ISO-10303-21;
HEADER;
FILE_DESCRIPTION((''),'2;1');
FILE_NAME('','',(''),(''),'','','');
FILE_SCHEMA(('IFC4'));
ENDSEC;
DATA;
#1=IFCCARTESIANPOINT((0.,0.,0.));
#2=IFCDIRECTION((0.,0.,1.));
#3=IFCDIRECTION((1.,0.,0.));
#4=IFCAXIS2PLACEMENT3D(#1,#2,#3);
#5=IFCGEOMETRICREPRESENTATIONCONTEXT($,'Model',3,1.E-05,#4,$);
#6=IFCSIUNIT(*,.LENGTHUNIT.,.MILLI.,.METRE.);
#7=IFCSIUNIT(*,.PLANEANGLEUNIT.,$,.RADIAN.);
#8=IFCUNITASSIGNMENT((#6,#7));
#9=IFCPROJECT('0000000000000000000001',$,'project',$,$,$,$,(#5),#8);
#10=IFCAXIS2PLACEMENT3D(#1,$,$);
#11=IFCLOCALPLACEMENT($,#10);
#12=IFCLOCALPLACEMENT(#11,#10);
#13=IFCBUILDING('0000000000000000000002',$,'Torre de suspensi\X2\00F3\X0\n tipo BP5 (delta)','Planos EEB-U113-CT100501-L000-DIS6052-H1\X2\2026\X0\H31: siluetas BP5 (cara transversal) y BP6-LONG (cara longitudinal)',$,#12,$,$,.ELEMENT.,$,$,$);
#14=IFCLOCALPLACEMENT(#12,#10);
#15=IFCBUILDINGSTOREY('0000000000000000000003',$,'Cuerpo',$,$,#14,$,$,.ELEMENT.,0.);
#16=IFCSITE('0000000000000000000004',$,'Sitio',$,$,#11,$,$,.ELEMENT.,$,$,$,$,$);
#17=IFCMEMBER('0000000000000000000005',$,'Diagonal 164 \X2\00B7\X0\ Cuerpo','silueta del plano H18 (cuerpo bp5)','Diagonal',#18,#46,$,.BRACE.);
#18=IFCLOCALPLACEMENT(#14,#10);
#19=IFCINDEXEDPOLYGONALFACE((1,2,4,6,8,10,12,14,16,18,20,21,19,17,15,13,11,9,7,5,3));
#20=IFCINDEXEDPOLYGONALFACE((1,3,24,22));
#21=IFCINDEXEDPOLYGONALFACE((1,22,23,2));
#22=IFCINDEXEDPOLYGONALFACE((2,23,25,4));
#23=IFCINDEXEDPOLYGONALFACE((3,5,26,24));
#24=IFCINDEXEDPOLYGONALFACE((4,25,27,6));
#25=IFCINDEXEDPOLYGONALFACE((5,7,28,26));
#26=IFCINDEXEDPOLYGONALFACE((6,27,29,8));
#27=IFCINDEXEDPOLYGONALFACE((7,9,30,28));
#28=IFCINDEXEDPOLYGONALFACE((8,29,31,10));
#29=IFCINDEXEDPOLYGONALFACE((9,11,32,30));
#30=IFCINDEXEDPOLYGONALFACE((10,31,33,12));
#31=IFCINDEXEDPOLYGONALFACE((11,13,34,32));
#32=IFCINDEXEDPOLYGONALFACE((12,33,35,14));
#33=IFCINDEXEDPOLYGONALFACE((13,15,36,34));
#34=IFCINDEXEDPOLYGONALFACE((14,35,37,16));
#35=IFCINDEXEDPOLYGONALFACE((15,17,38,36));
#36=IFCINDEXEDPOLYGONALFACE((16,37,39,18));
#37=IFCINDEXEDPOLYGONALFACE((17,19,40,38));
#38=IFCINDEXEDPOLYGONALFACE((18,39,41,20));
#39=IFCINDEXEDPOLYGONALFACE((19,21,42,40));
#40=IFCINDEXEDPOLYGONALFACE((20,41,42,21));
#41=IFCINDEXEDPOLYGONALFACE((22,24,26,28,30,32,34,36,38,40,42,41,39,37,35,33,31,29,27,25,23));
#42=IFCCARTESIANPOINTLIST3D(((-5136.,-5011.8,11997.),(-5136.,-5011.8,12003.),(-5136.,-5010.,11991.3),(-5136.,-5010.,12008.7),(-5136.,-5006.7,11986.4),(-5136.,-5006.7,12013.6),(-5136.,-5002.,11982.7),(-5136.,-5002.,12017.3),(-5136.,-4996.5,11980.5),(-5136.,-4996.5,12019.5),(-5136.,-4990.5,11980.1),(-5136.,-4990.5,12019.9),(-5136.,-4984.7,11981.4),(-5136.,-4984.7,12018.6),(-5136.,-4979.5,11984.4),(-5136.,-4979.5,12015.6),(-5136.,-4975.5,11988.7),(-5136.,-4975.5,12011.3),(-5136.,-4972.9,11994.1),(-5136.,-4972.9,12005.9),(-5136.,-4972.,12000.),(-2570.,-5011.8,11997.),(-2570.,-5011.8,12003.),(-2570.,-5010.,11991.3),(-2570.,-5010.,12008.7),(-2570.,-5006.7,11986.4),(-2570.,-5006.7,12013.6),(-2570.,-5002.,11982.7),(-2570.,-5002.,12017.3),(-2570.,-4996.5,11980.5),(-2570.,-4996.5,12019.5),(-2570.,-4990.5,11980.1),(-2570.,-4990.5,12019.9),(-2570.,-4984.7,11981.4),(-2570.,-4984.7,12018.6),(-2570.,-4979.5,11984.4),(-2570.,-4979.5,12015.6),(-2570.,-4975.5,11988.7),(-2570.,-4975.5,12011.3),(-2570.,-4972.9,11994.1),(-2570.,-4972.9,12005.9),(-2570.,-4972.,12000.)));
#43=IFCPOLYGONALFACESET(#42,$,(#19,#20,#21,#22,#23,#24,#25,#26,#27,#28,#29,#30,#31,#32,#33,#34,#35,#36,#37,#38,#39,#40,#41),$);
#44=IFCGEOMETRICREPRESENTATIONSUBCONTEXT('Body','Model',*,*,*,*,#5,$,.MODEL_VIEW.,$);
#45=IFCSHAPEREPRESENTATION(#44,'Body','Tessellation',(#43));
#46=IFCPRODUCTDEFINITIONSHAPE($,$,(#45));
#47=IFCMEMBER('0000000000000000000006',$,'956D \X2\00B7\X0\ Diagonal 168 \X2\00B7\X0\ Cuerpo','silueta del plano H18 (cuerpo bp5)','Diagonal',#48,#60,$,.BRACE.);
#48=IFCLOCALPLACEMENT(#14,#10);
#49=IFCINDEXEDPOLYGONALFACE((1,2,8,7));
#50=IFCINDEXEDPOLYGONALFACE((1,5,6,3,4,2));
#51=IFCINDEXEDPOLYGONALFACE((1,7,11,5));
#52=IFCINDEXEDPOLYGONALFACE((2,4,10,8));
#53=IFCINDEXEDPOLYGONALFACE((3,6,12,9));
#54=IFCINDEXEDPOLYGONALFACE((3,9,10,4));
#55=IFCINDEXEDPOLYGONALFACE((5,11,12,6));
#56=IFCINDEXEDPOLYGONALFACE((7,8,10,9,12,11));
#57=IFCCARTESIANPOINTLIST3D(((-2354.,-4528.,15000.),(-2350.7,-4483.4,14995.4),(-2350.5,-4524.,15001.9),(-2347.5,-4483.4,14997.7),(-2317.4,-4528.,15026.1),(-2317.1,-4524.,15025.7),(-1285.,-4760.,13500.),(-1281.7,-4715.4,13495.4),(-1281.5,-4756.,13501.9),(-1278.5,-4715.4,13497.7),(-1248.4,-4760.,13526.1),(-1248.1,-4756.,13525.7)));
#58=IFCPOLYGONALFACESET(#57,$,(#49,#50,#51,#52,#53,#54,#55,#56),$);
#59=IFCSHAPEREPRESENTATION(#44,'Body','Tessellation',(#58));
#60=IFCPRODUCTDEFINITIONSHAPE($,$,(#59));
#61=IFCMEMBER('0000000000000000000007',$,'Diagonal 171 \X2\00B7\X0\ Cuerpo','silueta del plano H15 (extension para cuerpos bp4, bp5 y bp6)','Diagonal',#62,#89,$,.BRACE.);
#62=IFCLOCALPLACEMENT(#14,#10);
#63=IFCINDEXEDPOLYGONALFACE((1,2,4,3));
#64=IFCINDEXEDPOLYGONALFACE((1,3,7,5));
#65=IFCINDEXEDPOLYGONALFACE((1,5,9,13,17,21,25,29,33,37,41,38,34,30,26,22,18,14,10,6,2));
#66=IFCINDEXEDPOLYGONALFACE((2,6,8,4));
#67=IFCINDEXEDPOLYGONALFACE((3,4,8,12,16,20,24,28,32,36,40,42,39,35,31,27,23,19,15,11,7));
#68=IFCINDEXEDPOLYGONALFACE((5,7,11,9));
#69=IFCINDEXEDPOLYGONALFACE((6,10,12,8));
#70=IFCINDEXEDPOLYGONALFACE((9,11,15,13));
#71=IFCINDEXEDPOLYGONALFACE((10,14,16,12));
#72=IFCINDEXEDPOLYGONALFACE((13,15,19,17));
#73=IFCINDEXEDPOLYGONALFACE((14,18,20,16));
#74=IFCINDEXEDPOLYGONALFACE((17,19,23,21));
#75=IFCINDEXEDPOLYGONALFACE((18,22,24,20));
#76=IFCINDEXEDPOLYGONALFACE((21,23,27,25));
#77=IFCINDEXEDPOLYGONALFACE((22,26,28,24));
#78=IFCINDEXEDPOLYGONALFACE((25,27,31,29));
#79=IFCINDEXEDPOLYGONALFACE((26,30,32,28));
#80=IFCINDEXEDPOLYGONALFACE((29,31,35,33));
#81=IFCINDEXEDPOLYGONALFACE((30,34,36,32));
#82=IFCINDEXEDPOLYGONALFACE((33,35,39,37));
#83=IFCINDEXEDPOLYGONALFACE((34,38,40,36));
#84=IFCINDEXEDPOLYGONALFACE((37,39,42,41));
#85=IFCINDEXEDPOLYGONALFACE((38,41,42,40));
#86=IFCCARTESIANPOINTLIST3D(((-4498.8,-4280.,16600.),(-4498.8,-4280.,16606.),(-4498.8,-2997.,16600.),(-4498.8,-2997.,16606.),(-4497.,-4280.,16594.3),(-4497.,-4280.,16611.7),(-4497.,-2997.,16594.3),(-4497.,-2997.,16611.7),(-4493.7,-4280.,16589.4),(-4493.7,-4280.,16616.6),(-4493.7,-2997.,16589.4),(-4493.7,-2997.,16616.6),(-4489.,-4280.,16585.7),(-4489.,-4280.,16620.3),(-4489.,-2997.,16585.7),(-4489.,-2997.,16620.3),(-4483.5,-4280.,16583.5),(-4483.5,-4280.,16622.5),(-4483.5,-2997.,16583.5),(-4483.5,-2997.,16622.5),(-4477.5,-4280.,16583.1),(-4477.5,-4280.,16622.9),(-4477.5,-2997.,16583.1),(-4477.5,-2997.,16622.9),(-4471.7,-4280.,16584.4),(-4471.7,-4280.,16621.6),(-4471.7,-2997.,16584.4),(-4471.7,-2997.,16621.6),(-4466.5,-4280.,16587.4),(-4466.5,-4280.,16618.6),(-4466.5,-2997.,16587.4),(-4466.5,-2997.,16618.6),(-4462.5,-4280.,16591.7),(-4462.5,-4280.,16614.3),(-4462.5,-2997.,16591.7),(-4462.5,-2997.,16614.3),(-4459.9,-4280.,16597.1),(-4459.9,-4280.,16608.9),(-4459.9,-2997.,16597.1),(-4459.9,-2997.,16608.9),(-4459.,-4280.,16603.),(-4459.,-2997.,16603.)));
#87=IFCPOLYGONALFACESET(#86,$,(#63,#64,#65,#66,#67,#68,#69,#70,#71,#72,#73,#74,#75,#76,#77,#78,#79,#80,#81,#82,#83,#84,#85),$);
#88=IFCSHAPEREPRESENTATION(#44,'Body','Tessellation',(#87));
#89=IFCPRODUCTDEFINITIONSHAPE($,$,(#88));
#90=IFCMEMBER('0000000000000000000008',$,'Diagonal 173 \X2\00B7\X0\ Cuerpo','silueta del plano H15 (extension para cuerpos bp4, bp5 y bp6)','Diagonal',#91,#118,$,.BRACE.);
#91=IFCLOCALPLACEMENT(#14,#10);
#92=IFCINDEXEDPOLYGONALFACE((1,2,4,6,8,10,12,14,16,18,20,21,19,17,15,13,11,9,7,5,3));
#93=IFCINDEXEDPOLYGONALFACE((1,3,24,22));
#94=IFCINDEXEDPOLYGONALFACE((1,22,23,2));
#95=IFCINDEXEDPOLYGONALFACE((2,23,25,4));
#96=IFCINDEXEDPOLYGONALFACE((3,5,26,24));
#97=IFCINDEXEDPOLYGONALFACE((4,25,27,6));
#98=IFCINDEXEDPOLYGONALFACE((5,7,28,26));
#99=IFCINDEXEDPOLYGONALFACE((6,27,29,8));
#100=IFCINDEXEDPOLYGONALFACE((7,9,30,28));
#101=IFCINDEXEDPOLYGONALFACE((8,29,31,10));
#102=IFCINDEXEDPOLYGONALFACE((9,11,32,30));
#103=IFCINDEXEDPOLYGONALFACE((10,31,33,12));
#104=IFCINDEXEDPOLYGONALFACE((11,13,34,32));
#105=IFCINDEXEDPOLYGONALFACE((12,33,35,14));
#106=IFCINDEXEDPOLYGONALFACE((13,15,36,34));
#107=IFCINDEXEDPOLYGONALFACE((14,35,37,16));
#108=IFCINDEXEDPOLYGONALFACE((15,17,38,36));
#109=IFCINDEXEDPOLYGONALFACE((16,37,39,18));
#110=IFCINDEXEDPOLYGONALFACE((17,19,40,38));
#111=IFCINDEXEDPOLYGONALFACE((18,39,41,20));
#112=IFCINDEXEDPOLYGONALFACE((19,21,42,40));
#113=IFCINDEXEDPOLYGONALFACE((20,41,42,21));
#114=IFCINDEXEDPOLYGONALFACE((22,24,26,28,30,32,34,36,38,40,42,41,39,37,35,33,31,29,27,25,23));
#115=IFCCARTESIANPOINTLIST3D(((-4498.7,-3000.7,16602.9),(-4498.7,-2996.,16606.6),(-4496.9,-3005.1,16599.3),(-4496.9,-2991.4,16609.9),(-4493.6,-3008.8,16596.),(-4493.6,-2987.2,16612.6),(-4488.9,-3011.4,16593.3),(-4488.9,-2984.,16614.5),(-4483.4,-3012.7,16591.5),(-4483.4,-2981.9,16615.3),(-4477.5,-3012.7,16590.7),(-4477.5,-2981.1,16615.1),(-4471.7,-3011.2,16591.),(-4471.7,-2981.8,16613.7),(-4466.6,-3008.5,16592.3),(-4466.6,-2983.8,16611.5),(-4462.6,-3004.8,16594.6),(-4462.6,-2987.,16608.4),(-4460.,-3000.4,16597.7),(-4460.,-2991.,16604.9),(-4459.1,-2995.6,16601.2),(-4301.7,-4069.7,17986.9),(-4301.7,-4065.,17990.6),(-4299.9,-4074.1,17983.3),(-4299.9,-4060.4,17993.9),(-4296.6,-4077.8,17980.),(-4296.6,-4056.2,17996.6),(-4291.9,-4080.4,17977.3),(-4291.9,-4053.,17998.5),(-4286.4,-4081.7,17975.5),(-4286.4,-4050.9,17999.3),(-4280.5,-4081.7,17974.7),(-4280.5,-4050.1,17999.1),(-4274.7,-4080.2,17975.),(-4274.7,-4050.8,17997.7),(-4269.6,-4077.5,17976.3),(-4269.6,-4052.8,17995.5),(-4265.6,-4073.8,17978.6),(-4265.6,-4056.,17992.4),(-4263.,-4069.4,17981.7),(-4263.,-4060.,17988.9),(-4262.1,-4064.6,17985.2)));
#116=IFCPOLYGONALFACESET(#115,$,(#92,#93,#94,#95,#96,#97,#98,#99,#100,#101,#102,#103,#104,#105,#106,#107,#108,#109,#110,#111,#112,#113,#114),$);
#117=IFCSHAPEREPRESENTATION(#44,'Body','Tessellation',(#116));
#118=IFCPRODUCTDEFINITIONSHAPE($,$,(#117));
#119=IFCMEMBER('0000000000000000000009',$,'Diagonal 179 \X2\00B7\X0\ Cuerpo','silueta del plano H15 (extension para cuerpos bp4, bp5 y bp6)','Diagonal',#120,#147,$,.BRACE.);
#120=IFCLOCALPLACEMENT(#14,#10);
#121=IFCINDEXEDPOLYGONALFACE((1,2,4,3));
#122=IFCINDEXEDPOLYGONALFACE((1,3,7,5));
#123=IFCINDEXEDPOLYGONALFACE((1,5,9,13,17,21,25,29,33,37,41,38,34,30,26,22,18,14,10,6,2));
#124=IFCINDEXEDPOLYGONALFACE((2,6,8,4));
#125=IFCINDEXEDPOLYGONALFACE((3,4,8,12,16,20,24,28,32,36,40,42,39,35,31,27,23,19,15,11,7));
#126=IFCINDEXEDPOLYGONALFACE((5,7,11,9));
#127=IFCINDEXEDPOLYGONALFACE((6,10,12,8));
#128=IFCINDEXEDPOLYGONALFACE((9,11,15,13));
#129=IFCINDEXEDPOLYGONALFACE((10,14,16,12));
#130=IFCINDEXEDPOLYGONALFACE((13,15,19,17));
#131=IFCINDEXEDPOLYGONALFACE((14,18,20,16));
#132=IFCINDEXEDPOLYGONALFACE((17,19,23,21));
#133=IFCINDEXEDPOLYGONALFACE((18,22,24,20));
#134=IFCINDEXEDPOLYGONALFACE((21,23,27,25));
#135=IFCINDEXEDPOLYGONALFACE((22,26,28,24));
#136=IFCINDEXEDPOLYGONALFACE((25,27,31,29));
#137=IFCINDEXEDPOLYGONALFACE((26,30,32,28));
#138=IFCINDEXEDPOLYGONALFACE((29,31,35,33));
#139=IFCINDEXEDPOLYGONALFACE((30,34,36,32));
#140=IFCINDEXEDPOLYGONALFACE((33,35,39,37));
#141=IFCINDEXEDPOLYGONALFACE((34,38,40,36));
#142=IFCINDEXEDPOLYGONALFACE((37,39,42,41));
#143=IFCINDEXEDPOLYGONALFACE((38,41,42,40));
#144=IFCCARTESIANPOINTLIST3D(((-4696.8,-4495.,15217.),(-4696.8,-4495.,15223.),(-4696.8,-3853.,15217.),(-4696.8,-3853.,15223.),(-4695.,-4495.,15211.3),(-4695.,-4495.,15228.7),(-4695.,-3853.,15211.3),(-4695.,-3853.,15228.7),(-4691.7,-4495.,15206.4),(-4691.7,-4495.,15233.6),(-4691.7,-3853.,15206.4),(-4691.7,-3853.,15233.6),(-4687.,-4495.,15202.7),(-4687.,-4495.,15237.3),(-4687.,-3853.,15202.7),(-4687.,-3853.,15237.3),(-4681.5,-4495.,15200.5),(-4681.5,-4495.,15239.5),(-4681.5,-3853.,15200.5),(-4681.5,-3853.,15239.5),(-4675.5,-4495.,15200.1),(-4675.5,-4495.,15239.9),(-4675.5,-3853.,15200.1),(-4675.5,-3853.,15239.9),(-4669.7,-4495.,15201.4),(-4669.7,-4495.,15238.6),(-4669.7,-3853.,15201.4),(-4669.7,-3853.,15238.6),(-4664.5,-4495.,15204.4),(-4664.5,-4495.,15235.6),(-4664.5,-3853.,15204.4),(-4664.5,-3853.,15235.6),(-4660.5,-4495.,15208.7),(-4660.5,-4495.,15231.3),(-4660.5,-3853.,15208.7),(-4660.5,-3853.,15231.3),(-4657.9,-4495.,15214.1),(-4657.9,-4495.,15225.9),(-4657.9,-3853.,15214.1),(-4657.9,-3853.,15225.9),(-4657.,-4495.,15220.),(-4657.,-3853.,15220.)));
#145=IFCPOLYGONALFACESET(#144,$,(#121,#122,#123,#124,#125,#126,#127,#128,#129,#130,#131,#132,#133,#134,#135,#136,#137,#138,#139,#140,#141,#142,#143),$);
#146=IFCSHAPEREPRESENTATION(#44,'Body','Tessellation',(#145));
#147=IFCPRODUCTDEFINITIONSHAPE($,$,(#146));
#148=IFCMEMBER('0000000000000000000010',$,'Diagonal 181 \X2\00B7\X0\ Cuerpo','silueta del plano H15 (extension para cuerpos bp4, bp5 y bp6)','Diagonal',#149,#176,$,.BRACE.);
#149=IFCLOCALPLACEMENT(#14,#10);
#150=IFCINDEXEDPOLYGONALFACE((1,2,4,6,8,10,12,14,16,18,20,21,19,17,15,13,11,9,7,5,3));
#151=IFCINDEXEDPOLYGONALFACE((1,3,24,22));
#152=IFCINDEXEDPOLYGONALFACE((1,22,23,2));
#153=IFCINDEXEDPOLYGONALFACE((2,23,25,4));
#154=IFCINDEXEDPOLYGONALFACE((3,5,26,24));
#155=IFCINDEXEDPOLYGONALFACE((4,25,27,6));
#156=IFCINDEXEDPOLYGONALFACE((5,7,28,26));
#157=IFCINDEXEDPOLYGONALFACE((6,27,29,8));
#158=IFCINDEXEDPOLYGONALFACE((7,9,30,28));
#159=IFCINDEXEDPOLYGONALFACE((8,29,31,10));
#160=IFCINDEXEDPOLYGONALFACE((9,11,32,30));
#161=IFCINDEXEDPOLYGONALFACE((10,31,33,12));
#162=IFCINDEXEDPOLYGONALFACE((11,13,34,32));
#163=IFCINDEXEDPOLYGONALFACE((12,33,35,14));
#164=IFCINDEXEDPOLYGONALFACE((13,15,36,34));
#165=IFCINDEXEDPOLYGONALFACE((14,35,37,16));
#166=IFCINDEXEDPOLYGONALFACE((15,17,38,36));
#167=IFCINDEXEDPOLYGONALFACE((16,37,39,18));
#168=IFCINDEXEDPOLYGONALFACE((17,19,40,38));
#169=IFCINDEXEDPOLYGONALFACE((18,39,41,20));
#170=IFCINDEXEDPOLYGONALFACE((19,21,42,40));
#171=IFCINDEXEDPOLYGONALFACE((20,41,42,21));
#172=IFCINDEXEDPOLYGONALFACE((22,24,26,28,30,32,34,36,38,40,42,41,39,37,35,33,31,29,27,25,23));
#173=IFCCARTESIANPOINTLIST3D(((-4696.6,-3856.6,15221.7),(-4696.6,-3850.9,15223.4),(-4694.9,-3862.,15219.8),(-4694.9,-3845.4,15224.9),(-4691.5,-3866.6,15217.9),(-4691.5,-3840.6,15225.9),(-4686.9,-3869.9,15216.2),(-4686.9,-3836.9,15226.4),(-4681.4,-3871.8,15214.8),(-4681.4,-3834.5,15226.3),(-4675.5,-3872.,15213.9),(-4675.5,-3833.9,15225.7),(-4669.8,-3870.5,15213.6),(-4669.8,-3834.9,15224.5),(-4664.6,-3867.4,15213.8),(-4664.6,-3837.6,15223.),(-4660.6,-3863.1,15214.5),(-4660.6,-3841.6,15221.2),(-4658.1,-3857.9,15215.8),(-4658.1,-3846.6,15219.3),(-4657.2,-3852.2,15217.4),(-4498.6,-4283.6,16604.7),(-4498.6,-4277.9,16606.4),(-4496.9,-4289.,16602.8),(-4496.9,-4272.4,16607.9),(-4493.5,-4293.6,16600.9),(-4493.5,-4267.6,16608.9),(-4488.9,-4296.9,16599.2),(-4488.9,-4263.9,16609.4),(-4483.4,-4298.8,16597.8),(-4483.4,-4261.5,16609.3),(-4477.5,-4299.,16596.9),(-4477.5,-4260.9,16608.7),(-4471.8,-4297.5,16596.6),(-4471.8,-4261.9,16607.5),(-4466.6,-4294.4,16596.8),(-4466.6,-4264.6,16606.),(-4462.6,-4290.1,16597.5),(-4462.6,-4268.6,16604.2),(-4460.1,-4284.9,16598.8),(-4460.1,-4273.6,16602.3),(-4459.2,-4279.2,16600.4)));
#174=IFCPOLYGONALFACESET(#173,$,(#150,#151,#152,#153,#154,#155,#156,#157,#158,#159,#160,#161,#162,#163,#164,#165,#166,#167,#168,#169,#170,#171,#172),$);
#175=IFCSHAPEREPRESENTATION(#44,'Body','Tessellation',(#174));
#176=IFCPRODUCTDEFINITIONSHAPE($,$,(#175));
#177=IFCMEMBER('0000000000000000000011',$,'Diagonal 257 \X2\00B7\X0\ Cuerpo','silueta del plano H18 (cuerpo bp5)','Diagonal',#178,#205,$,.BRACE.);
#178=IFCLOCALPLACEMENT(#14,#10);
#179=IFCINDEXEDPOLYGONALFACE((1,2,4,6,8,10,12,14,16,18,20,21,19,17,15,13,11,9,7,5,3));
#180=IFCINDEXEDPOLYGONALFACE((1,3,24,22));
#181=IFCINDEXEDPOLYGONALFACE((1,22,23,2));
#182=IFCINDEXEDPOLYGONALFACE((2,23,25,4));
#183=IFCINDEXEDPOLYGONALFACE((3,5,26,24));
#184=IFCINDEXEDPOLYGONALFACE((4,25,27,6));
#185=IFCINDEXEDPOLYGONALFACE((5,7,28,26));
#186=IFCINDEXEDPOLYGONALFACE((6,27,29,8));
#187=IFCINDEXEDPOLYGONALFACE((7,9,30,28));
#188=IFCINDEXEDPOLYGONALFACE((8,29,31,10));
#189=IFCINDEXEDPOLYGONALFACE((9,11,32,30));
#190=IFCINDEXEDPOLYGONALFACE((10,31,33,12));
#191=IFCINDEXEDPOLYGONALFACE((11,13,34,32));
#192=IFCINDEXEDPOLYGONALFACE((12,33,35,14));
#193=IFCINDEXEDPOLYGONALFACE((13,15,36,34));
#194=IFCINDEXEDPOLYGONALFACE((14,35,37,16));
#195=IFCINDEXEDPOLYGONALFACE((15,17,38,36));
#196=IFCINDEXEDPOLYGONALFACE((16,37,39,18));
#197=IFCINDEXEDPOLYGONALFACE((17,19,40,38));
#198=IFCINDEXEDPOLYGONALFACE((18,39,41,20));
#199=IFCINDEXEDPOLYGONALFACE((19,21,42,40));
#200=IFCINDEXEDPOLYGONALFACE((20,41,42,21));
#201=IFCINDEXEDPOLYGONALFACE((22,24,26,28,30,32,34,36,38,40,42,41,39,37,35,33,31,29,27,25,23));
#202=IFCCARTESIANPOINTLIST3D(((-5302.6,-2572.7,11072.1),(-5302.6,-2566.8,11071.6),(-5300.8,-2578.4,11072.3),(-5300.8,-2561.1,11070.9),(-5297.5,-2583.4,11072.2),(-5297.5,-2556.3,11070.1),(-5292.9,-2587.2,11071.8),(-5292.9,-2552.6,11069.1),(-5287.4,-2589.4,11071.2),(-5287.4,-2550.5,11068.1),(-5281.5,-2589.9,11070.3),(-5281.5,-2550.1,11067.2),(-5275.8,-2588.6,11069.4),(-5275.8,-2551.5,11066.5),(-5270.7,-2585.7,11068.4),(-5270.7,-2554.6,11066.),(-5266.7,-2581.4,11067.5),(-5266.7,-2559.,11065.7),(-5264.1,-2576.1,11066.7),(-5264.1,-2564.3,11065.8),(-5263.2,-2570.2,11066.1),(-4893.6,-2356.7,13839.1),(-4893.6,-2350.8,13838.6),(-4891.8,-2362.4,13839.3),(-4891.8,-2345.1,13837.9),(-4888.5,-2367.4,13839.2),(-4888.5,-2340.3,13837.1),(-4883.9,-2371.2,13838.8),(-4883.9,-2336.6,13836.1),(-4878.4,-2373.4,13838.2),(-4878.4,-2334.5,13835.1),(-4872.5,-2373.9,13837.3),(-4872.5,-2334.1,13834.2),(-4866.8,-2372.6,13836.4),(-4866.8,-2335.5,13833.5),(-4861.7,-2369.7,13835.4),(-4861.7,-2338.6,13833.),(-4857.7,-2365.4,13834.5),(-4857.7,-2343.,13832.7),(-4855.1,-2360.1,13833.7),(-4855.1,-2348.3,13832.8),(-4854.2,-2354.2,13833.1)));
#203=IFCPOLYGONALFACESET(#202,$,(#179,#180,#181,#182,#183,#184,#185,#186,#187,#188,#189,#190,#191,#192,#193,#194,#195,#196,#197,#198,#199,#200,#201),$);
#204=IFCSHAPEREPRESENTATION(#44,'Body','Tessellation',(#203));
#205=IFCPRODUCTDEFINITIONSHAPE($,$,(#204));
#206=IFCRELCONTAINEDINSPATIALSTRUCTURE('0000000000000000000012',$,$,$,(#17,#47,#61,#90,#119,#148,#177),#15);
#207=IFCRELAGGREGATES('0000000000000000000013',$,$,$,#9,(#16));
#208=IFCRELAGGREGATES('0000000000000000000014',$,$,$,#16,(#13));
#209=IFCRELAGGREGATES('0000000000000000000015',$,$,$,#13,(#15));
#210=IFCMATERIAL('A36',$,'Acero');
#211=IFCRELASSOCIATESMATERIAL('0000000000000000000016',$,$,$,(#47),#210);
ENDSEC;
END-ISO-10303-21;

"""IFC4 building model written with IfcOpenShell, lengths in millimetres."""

from ifc_helpers import new_model, si_unit, frame, frame_2d, origin, origin_with_axes, place, context, subcontext, project, spatial, circle, l_section, extrude, material, element, save


model = new_model("IFC4")

# Units and contexts
model_context = context("Model", 3, precision=1e-05, world=origin_with_axes())
body_context = subcontext(model_context, "Body", "Model", "MODEL_VIEW")
ifc_project = project(units=[si_unit("LENGTHUNIT", "METRE", prefix="MILLI"), si_unit("PLANEANGLEUNIT", "RADIAN")], contexts=[model_context])

# Site, building, storey
site_placement = place(None, origin())
site = spatial("IfcSite", under=ifc_project, at=site_placement, Name="Sitio", CompositionType="ELEMENT")
building_placement = place(site_placement, origin())
building = spatial("IfcBuilding", under=site, at=building_placement, Name="Torre de suspensión tipo BP5 (delta)", Description="Planos EEB-U113-CT100501-L000-DIS6052-H1…H31: siluetas BP5 (cara transversal) y BP6-LONG (cara longitudinal)", CompositionType="ELEMENT")
storey_placement = place(building_placement, origin())
storey = spatial("IfcBuildingStorey", under=building, at=storey_placement, Name="Cuerpo", CompositionType="ELEMENT", Elevation=0.0)

# Members
ifc_material_1 = material(Name="A36", Category="Acero")
member_1_placement = place(storey_placement, frame((-5136.0, -4992.0, 12000.0), z_axis=(1.0, 0.0, 0.0), x_axis=(0.0, 1.0, 0.0)))
element("IfcMember", 1, at=member_1_placement, inside=storey, Name="Diagonal 164 · Cuerpo", Description="silueta del plano H18 (cuerpo bp5)", ObjectType="Diagonal", PredefinedType="BRACE", context=body_context, shape_type="SweptSolid", body=[
    extrude(circle(Radius=20.0), None, (0.0, 0.0, 1.0), 2566.0),
])
member_2_placement = place(storey_placement, frame((-2354.0, -4528.0, 15000.0), z_axis=(0.575815, -0.124966, -0.807973), x_axis=(0.072526, 0.992161, -0.101767)))
element("IfcMember", 2, at=member_2_placement, inside=storey, material=ifc_material_1, Name="956D · Diagonal 168 · Cuerpo", Description="silueta del plano H18 (cuerpo bp5)", ObjectType="Diagonal", PredefinedType="BRACE", context=body_context, shape_type="SweptSolid", body=[
    extrude(l_section(Depth=45.0, Width=45.0, Thickness=4.0, at=frame_2d((22.5, 22.5))), None, (0.0, 0.0, 1.0), 1856.5),
])
member_3_placement = place(storey_placement, frame((-4479.0, -2997.0, 16603.0), z_axis=(0.0, -1.0, 0.0), x_axis=(1.0, 0.0, 0.0)))
element("IfcMember", 3, at=member_3_placement, inside=storey, Name="Diagonal 171 · Cuerpo", Description="silueta del plano H15 (extension para cuerpos bp4, bp5 y bp6)", ObjectType="Diagonal", PredefinedType="BRACE", context=body_context, shape_type="SweptSolid", body=[
    extrude(circle(Radius=20.0), None, (0.0, 0.0, 1.0), 1283.0),
])
member_4_placement = place(storey_placement, frame((-4479.0, -2997.0, 16603.0), z_axis=(0.111942, -0.607443, 0.786437), x_axis=(0.993715, 0.068429, -0.088592)))
element("IfcMember", 4, at=member_4_placement, inside=storey, Name="Diagonal 173 · Cuerpo", Description="silueta del plano H15 (extension para cuerpos bp4, bp5 y bp6)", ObjectType="Diagonal", PredefinedType="BRACE", context=body_context, shape_type="SweptSolid", body=[
    extrude(circle(Radius=20.0), None, (0.0, 0.0, 1.0), 1759.8),
])
member_5_placement = place(storey_placement, frame((-4677.0, -3853.0, 15220.0), z_axis=(0.0, -1.0, 0.0), x_axis=(1.0, 0.0, 0.0)))
element("IfcMember", 5, at=member_5_placement, inside=storey, Name="Diagonal 179 · Cuerpo", Description="silueta del plano H15 (extension para cuerpos bp4, bp5 y bp6)", ObjectType="Diagonal", PredefinedType="BRACE", context=body_context, shape_type="SweptSolid", body=[
    extrude(circle(Radius=20.0), None, (0.0, 0.0, 1.0), 642.0),
])
member_6_placement = place(storey_placement, frame((-4677.0, -3853.0, 15220.0), z_axis=(0.135533, -0.292286, 0.946678), x_axis=(0.990773, 0.039983, -0.129501)))
element("IfcMember", 6, at=member_6_placement, inside=storey, Name="Diagonal 181 · Cuerpo", Description="silueta del plano H15 (extension para cuerpos bp4, bp5 y bp6)", ObjectType="Diagonal", PredefinedType="BRACE", context=body_context, shape_type="SweptSolid", body=[
    extrude(circle(Radius=20.0), None, (0.0, 0.0, 1.0), 1460.9),
])
member_7_placement = place(storey_placement, frame((-5283.0, -2570.0, 11069.0), z_axis=(0.145791, 0.076995, 0.986315), x_axis=(0.989315, -0.011346, -0.145348)))
element("IfcMember", 7, at=member_7_placement, inside=storey, Name="Diagonal 257 · Cuerpo", Description="silueta del plano H18 (cuerpo bp5)", ObjectType="Diagonal", PredefinedType="BRACE", context=body_context, shape_type="SweptSolid", body=[
    extrude(circle(Radius=20.0), None, (0.0, 0.0, 1.0), 2805.4),
])

save(model, "model.ifc")
